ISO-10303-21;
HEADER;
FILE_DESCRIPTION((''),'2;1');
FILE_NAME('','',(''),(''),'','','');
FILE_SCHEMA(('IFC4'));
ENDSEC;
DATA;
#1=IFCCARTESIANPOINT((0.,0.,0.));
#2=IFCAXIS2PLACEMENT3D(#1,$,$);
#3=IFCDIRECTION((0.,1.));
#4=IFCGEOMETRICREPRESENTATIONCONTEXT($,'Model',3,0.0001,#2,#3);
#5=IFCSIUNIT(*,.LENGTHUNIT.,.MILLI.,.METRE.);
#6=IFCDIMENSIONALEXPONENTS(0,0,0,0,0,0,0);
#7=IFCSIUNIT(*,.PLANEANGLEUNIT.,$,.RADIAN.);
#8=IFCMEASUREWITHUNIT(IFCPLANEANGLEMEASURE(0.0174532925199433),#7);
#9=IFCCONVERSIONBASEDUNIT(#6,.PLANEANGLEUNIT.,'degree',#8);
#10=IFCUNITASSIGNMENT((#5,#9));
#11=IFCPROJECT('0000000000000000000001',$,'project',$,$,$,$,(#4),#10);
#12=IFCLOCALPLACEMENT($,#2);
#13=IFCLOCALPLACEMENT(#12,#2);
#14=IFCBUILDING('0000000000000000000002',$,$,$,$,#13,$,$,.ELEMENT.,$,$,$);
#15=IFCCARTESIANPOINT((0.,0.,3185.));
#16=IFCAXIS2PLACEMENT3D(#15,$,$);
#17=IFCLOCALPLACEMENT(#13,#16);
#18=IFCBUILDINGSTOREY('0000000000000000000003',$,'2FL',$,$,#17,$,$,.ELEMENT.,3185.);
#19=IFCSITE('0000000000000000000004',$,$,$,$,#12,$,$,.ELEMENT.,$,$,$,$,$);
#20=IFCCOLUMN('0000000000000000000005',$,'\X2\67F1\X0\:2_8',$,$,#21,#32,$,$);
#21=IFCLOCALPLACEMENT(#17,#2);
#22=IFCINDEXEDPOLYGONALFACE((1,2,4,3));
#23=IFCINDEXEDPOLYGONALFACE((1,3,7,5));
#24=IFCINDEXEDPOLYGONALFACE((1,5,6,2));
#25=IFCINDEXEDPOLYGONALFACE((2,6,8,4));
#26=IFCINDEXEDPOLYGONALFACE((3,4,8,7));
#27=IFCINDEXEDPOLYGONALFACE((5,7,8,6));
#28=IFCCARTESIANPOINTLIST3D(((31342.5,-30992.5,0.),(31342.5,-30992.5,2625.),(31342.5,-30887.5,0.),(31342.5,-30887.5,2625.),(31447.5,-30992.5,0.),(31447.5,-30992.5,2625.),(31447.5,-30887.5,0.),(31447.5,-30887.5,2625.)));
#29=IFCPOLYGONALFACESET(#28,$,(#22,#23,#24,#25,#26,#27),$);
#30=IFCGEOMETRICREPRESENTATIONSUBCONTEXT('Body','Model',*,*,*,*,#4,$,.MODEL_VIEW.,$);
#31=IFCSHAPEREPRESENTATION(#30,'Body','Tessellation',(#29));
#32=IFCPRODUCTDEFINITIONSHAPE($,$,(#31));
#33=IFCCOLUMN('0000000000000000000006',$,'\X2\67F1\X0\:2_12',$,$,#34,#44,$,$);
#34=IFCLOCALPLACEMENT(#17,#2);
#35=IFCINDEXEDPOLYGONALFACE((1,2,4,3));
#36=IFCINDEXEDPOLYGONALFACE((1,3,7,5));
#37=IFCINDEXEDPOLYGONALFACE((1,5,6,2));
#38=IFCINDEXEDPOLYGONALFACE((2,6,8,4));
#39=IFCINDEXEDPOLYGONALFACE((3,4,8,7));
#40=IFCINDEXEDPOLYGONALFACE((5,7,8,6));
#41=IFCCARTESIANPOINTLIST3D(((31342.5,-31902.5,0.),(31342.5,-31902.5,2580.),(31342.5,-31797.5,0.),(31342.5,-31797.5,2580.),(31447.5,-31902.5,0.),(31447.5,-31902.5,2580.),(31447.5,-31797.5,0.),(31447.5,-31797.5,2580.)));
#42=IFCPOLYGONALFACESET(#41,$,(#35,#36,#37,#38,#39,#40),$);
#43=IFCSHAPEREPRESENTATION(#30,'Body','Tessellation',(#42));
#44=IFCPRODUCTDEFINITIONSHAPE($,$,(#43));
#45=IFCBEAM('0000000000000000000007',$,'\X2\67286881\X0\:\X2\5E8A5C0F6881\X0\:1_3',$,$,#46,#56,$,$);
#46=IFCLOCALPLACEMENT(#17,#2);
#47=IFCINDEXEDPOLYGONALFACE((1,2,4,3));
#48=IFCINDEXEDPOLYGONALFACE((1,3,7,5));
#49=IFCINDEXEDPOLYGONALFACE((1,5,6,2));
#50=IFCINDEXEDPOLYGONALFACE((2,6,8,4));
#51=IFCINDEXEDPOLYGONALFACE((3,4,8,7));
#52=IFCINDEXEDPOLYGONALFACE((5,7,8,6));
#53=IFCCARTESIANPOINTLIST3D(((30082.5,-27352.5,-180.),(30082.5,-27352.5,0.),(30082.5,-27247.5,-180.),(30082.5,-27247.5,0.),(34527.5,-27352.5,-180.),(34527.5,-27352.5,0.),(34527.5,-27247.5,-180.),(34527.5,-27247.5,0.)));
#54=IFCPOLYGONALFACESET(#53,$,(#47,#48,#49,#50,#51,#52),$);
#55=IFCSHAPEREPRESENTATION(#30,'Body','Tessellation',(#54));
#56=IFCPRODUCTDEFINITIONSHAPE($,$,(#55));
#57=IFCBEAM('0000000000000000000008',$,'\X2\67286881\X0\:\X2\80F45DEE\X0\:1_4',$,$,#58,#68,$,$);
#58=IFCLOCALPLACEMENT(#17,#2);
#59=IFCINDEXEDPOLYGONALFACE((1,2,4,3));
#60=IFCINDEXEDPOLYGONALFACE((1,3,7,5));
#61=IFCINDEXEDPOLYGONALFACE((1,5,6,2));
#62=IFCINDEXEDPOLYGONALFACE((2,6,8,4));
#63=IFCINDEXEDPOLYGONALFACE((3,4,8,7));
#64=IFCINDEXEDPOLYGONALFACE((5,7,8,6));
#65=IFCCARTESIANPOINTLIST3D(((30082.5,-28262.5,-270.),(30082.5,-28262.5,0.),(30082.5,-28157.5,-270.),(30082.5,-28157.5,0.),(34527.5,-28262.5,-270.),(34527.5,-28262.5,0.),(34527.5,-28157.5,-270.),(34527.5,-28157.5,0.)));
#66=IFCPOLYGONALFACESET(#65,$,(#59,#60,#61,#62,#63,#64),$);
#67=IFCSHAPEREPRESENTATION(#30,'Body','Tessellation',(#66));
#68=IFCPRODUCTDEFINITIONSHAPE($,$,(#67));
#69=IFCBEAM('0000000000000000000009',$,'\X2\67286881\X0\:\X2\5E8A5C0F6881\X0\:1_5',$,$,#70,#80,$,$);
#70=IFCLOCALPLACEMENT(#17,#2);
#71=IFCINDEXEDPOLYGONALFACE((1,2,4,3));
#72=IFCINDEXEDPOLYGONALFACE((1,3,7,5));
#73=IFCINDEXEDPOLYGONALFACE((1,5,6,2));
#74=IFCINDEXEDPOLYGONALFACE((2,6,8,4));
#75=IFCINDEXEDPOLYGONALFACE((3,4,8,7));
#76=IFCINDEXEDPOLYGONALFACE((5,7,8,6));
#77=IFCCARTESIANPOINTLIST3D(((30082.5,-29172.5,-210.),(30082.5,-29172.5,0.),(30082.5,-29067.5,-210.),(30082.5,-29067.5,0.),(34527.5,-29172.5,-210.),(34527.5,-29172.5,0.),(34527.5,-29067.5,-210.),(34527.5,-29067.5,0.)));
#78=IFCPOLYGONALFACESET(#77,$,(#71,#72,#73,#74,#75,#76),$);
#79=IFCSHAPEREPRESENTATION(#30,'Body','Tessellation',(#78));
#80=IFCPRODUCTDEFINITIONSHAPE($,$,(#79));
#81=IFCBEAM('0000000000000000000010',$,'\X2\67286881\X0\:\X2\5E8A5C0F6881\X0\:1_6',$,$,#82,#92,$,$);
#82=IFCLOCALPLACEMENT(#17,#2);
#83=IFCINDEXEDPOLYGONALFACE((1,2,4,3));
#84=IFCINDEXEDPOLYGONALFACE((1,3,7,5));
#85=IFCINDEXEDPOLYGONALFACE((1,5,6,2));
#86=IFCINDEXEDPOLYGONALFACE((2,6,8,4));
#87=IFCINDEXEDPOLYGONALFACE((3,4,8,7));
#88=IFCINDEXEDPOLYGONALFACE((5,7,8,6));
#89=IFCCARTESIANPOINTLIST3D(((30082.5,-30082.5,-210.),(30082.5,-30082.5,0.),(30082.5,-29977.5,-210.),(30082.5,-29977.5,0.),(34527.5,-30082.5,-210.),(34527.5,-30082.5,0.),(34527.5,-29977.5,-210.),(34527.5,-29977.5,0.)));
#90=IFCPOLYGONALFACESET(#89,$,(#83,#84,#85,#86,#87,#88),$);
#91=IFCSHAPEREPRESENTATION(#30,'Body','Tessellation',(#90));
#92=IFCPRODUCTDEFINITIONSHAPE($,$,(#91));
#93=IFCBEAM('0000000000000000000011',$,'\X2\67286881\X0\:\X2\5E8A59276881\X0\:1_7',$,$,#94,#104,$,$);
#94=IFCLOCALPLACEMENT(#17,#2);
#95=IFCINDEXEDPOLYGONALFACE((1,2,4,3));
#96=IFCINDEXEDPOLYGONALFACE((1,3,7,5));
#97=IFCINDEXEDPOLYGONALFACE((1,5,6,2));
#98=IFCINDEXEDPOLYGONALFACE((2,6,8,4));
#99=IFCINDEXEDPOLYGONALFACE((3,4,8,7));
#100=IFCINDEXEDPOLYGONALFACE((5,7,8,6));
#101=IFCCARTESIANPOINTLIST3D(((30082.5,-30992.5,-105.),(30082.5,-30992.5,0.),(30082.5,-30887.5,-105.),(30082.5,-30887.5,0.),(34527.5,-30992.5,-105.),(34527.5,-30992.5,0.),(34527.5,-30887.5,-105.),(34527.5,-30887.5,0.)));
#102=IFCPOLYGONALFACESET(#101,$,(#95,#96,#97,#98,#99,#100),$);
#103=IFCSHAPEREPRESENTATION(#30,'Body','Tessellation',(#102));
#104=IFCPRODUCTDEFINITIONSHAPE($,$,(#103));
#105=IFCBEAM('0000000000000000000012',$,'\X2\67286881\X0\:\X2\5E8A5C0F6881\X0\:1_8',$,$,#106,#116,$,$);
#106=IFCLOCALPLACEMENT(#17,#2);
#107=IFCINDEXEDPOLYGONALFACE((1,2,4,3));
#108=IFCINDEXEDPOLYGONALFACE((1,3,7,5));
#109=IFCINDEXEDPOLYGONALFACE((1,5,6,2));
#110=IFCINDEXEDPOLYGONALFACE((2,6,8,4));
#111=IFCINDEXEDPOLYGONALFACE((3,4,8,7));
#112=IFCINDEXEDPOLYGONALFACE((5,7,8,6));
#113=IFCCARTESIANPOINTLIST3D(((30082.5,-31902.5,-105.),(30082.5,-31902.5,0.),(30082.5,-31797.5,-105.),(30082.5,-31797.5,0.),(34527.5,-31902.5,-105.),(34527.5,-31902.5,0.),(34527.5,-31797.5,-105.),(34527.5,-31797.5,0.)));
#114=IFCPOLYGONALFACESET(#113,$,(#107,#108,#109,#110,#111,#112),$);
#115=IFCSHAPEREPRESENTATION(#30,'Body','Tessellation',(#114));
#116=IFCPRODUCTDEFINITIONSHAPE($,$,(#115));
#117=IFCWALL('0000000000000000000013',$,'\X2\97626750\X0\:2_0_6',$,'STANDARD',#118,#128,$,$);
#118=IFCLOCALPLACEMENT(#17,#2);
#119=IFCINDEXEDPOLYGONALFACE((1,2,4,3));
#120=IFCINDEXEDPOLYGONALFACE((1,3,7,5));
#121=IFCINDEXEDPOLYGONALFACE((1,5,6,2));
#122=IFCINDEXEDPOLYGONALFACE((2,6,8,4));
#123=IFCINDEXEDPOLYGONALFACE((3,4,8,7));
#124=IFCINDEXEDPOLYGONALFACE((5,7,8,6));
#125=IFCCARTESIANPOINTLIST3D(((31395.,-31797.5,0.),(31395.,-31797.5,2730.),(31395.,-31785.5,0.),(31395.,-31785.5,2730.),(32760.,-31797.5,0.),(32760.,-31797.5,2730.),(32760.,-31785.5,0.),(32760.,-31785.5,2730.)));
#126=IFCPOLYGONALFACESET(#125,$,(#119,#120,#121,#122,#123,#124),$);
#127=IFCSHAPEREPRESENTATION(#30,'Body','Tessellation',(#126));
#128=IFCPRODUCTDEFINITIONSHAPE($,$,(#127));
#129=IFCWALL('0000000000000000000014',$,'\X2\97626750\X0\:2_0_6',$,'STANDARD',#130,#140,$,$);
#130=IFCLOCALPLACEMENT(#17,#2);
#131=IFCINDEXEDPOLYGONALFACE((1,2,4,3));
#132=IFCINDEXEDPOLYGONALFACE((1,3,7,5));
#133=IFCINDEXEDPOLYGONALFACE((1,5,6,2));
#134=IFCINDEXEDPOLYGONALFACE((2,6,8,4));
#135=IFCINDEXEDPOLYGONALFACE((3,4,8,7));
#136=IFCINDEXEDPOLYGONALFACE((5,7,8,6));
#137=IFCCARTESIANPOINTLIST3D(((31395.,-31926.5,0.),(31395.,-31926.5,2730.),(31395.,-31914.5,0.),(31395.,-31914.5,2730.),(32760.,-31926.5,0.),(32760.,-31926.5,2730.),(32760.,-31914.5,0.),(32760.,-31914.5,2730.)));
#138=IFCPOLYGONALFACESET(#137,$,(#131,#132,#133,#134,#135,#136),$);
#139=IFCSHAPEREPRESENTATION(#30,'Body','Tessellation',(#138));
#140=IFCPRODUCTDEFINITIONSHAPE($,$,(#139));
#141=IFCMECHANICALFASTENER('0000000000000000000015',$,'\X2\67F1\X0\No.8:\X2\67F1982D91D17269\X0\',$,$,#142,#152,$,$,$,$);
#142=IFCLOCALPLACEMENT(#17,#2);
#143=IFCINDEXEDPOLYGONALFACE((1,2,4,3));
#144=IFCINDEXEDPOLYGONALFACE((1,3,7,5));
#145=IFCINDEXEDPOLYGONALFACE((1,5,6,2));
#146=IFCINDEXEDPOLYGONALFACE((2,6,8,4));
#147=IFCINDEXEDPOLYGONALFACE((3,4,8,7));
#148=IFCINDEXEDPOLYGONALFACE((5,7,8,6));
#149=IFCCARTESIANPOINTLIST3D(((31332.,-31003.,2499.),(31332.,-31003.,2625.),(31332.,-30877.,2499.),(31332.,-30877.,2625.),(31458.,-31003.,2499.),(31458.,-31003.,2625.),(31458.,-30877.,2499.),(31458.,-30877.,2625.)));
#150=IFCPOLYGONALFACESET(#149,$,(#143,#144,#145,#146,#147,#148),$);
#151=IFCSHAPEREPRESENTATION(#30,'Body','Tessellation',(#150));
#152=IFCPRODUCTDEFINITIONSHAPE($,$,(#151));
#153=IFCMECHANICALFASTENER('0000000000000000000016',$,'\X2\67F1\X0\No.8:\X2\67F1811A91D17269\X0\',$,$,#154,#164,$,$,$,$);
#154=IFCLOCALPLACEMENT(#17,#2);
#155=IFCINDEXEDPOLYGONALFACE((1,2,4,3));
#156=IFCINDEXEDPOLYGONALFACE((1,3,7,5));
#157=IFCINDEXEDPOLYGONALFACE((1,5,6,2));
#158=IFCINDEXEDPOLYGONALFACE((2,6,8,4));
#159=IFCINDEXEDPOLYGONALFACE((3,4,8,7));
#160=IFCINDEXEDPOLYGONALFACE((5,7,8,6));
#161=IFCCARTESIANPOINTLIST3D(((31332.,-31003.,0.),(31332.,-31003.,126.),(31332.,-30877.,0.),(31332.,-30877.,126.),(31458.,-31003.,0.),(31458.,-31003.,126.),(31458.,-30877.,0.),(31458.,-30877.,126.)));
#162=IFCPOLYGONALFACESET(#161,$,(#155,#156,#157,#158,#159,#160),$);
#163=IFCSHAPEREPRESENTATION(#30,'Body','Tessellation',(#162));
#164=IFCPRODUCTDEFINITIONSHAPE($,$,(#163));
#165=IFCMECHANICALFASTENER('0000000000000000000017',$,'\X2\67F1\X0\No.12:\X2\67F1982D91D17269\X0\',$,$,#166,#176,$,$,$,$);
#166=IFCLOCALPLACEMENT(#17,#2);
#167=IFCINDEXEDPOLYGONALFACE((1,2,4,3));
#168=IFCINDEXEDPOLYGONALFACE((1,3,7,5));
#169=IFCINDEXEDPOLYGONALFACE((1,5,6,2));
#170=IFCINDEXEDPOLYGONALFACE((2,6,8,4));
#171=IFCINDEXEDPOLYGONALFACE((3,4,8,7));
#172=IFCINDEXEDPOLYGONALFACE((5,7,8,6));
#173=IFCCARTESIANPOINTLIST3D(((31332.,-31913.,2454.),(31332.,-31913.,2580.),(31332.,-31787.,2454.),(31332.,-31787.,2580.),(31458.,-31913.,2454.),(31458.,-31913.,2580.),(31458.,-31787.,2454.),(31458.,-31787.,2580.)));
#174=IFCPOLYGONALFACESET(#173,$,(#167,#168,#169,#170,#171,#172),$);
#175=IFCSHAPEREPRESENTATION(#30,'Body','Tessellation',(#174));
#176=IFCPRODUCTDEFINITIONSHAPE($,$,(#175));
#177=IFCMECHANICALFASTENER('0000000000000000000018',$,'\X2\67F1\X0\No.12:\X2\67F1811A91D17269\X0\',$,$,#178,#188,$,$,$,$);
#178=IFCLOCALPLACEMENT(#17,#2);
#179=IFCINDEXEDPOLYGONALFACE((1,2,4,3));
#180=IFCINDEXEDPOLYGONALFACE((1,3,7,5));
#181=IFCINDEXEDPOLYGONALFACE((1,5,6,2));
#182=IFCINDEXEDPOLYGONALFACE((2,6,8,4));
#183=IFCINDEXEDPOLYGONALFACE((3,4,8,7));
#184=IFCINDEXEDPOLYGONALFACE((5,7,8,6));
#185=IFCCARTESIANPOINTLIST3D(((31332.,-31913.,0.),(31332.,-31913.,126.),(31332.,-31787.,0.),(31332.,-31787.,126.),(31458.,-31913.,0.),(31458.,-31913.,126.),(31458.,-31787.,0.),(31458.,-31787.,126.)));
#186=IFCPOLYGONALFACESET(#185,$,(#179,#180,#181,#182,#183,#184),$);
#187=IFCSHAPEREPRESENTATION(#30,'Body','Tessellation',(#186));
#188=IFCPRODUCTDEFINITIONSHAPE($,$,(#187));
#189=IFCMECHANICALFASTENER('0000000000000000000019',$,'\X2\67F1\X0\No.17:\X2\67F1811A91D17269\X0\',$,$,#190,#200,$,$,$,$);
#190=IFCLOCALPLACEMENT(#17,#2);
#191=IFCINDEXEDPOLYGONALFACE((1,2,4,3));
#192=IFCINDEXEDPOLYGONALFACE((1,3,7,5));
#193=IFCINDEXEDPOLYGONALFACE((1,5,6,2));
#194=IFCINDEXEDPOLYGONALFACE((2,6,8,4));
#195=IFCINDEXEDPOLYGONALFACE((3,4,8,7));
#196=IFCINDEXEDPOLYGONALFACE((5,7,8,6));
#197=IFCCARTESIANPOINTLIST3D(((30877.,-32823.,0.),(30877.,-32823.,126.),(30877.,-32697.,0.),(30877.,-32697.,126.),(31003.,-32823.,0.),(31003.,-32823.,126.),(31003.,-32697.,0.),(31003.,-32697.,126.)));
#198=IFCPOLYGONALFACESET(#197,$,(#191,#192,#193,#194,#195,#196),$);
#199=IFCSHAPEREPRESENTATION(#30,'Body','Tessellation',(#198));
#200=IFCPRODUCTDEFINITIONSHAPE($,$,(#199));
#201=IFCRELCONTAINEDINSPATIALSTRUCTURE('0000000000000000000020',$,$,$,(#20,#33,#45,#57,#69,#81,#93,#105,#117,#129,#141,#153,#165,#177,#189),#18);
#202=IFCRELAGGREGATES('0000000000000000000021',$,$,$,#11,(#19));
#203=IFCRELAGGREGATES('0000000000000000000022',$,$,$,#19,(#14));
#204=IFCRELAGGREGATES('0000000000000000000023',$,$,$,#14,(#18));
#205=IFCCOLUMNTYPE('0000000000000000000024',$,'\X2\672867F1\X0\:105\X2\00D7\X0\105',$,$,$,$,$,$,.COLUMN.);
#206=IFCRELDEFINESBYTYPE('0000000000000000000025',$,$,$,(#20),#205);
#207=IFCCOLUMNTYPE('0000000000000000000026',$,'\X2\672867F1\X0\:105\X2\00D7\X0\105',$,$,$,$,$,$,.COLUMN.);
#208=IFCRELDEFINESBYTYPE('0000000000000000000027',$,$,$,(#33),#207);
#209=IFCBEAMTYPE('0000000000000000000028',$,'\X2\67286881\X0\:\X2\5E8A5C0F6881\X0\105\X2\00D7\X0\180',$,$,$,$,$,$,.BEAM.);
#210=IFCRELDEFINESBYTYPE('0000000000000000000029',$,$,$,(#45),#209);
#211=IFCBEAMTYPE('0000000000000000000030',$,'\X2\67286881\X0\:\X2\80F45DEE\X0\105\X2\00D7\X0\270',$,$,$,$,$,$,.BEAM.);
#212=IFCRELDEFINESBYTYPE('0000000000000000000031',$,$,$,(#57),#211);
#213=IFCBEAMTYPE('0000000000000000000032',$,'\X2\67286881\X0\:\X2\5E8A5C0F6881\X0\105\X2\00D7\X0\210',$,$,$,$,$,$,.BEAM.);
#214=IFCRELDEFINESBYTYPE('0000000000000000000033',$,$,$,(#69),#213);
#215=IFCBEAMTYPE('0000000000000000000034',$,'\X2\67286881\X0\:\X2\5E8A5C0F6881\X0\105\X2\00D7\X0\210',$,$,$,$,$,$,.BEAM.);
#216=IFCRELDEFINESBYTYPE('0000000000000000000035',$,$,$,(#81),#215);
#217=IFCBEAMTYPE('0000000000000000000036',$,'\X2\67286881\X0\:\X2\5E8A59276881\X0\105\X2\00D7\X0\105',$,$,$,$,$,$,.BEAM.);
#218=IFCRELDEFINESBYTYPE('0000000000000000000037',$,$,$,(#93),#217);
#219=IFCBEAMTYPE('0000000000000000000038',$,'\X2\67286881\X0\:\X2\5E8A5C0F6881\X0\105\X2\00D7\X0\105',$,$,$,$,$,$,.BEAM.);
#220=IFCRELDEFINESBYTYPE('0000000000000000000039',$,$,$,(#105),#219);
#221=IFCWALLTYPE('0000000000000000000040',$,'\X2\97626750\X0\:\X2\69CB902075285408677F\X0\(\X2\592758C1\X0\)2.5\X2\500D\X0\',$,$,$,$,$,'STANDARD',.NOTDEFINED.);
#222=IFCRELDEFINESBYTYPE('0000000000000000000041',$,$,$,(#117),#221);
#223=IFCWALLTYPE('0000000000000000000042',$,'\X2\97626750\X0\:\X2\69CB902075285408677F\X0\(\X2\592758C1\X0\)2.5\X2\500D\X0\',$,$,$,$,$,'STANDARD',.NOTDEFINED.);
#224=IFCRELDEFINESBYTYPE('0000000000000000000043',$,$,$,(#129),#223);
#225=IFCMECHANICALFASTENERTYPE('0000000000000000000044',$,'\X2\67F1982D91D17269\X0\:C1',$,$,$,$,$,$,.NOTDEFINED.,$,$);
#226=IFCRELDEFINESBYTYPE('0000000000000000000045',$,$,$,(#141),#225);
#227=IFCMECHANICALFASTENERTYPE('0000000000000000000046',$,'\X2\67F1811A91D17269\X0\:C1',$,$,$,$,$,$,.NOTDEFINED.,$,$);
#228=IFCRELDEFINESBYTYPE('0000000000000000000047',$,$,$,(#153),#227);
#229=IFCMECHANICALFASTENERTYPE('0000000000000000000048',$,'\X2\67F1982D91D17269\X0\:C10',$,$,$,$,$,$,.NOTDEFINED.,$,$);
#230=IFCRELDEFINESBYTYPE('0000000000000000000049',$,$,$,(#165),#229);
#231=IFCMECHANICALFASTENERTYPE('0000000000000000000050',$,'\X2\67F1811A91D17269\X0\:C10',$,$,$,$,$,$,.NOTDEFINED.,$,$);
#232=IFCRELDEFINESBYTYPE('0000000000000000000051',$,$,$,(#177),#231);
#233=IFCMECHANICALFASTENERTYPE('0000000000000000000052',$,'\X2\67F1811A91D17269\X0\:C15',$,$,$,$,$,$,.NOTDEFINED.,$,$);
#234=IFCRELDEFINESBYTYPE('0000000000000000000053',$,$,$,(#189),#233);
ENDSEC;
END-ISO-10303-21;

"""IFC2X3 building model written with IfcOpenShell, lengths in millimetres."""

from ifc_helpers import new_model, entity, si_unit, converted_unit, direction, frame, origin, origin_with_axes, origin_2d, place, context, subcontext, project, spatial, polyline, rectangle, outline, extrude, type_object, element, save


model = new_model("IFC2X3")

# Units and contexts
model_context = context("Model", 3, precision=0.0001, world=origin(), true_north=direction((0.0, 1.0)))
body_context = subcontext(model_context, "Body", "Model", "MODEL_VIEW")
ifc_project = project(units=[si_unit("LENGTHUNIT", "METRE", prefix="MILLI"), converted_unit("PLANEANGLEUNIT", "degree", entity("IfcPlaneAngleMeasure", 0.0174532925199433), si_unit("PLANEANGLEUNIT", "RADIAN"), dimensions=[0, 0, 0, 0, 0, 0, 0])], contexts=[model_context])

# Site, building, storey
site_placement = place(None, origin())
site = spatial("IfcSite", under=ifc_project, at=site_placement, CompositionType="ELEMENT")
building_placement = place(site_placement, origin())
building = spatial("IfcBuilding", under=site, at=building_placement, CompositionType="ELEMENT")
storey_placement = place(building_placement, frame((0.0, 0.0, 3185.0)))
storey = spatial("IfcBuildingStorey", under=building, at=storey_placement, Name="2FL", CompositionType="ELEMENT", Elevation=3185.0)

# Columns
column_type_1 = type_object("IfcColumnType", Name="木柱:105×105", PredefinedType="COLUMN")
column_1_placement = place(storey_placement, frame((31395.0, -30940.0, 0.0)))
element("IfcColumn", 1, at=column_1_placement, inside=storey, type_object=column_type_1, Name="柱:2_8", context=body_context, shape_type="SweptSolid", body=[
    extrude(rectangle(XDim=105.0, YDim=105.0, at=origin_2d()), origin_with_axes(), (0.0, 0.0, 1.0), 2625.0),
])
column_type_2 = type_object("IfcColumnType", Name="木柱:105×105", PredefinedType="COLUMN")
column_2_placement = place(storey_placement, frame((31395.0, -31850.0, 0.0)))
element("IfcColumn", 2, at=column_2_placement, inside=storey, type_object=column_type_2, Name="柱:2_12", context=body_context, shape_type="SweptSolid", body=[
    extrude(rectangle(XDim=105.0, YDim=105.0, at=origin_2d()), origin_with_axes(), (0.0, 0.0, 1.0), 2580.0),
])

# Beams
beam_type_1 = type_object("IfcBeamType", Name="木梁:床小梁105×180", PredefinedType="BEAM")
beam_1_placement = place(storey_placement, frame((30082.5, -27300.0, -90.0), z_axis=(1.0, 0.0, 0.0), x_axis=(0.0, 1.0, 0.0)))
element("IfcBeam", 3, at=beam_1_placement, inside=storey, type_object=beam_type_1, Name="木梁:床小梁:1_3", context=body_context, shape_type="SweptSolid", body=[
    extrude(rectangle(XDim=105.0, YDim=180.0, at=origin_2d()), origin_with_axes(), (0.0, 0.0, 1.0), 4445.0),
])
beam_type_2 = type_object("IfcBeamType", Name="木梁:胴差105×270", PredefinedType="BEAM")
beam_2_placement = place(storey_placement, frame((30082.5, -28210.0, -135.0), z_axis=(1.0, 0.0, 0.0), x_axis=(0.0, 1.0, 0.0)))
element("IfcBeam", 4, at=beam_2_placement, inside=storey, type_object=beam_type_2, Name="木梁:胴差:1_4", context=body_context, shape_type="SweptSolid", body=[
    extrude(rectangle(XDim=105.0, YDim=270.0, at=origin_2d()), origin_with_axes(), (0.0, 0.0, 1.0), 4445.0),
])
beam_type_3 = type_object("IfcBeamType", Name="木梁:床小梁105×210", PredefinedType="BEAM")
beam_3_placement = place(storey_placement, frame((30082.5, -29120.0, -105.0), z_axis=(1.0, 0.0, 0.0), x_axis=(0.0, 1.0, 0.0)))
element("IfcBeam", 5, at=beam_3_placement, inside=storey, type_object=beam_type_3, Name="木梁:床小梁:1_5", context=body_context, shape_type="SweptSolid", body=[
    extrude(rectangle(XDim=105.0, YDim=210.0, at=origin_2d()), origin_with_axes(), (0.0, 0.0, 1.0), 4445.0),
])
beam_type_4 = type_object("IfcBeamType", Name="木梁:床小梁105×210", PredefinedType="BEAM")
beam_4_placement = place(storey_placement, frame((30082.5, -30030.0, -105.0), z_axis=(1.0, 0.0, 0.0), x_axis=(0.0, 1.0, 0.0)))
element("IfcBeam", 6, at=beam_4_placement, inside=storey, type_object=beam_type_4, Name="木梁:床小梁:1_6", context=body_context, shape_type="SweptSolid", body=[
    extrude(rectangle(XDim=105.0, YDim=210.0, at=origin_2d()), origin_with_axes(), (0.0, 0.0, 1.0), 4445.0),
])
beam_type_5 = type_object("IfcBeamType", Name="木梁:床大梁105×105", PredefinedType="BEAM")
beam_5_placement = place(storey_placement, frame((30082.5, -30940.0, -52.5), z_axis=(1.0, 0.0, 0.0), x_axis=(0.0, 1.0, 0.0)))
element("IfcBeam", 7, at=beam_5_placement, inside=storey, type_object=beam_type_5, Name="木梁:床大梁:1_7", context=body_context, shape_type="SweptSolid", body=[
    extrude(rectangle(XDim=105.0, YDim=105.0, at=origin_2d()), origin_with_axes(), (0.0, 0.0, 1.0), 4445.0),
])
beam_type_6 = type_object("IfcBeamType", Name="木梁:床小梁105×105", PredefinedType="BEAM")
beam_6_placement = place(storey_placement, frame((30082.5, -31850.0, -52.5), z_axis=(1.0, 0.0, 0.0), x_axis=(0.0, 1.0, 0.0)))
element("IfcBeam", 8, at=beam_6_placement, inside=storey, type_object=beam_type_6, Name="木梁:床小梁:1_8", context=body_context, shape_type="SweptSolid", body=[
    extrude(rectangle(XDim=105.0, YDim=105.0, at=origin_2d()), origin_with_axes(), (0.0, 0.0, 1.0), 4445.0),
])

# Walls
wall_type_1 = type_object("IfcWallType", Name="面材:構造用合板(大壁)2.5倍", ElementType="STANDARD", PredefinedType="NOTDEFINED")
wall_1_placement = place(storey_placement, frame((32077.5, -31785.5, 0.0), z_axis=(0.0, -1.0, 0.0), x_axis=(1.0, 0.0, 0.0)))
element("IfcWall", 9, at=wall_1_placement, inside=storey, type_object=wall_type_1, Name="面材:2_0_6", ObjectType="STANDARD", context=body_context, shape_type="SweptSolid", body=[
    extrude(outline(polyline([(682.5, 0.0, 0.0), (-682.5, 0.0, 0.0), (-682.5, 2730.0, 0.0), (682.5, 2730.0, 0.0), (682.5, 0.0, 0.0)])), origin_with_axes(), (0.0, 0.0, 1.0), 12.0),
])
wall_type_2 = type_object("IfcWallType", Name="面材:構造用合板(大壁)2.5倍", ElementType="STANDARD", PredefinedType="NOTDEFINED")
wall_2_placement = place(storey_placement, frame((32077.5, -31914.5, 0.0), z_axis=(0.0, -1.0, 0.0), x_axis=(1.0, 0.0, 0.0)))
element("IfcWall", 10, at=wall_2_placement, inside=storey, type_object=wall_type_2, Name="面材:2_0_6", ObjectType="STANDARD", context=body_context, shape_type="SweptSolid", body=[
    extrude(outline(polyline([(682.5, 0.0, 0.0), (-682.5, 0.0, 0.0), (-682.5, 2730.0, 0.0), (682.5, 2730.0, 0.0), (682.5, 0.0, 0.0)])), origin_with_axes(), (0.0, 0.0, 1.0), 12.0),
])

# Mechanical fasteners
mechanical_fastener_type_1 = type_object("IfcMechanicalFastenerType", Name="柱頭金物:C1")
mechanical_fastener_1_placement = place(storey_placement, frame((31395.0, -30940.0, 2499.0)))
element("IfcMechanicalFastener", 11, at=mechanical_fastener_1_placement, inside=storey, type_object=mechanical_fastener_type_1, Name="柱No.8:柱頭金物", context=body_context, shape_type="SweptSolid", body=[
    extrude(rectangle(XDim=126.0, YDim=126.0, at=origin_2d()), origin_with_axes(), (0.0, 0.0, 1.0), 126.0),
])
mechanical_fastener_type_2 = type_object("IfcMechanicalFastenerType", Name="柱脚金物:C1")
mechanical_fastener_2_placement = place(storey_placement, frame((31395.0, -30940.0, 0.0)))
element("IfcMechanicalFastener", 12, at=mechanical_fastener_2_placement, inside=storey, type_object=mechanical_fastener_type_2, Name="柱No.8:柱脚金物", context=body_context, shape_type="SweptSolid", body=[
    extrude(rectangle(XDim=126.0, YDim=126.0, at=origin_2d()), origin_with_axes(), (0.0, 0.0, 1.0), 126.0),
])
mechanical_fastener_type_3 = type_object("IfcMechanicalFastenerType", Name="柱頭金物:C10")
mechanical_fastener_3_placement = place(storey_placement, frame((31395.0, -31850.0, 2454.0)))
element("IfcMechanicalFastener", 13, at=mechanical_fastener_3_placement, inside=storey, type_object=mechanical_fastener_type_3, Name="柱No.12:柱頭金物", context=body_context, shape_type="SweptSolid", body=[
    extrude(rectangle(XDim=126.0, YDim=126.0, at=origin_2d()), origin_with_axes(), (0.0, 0.0, 1.0), 126.0),
])
mechanical_fastener_type_4 = type_object("IfcMechanicalFastenerType", Name="柱脚金物:C10")
mechanical_fastener_4_placement = place(storey_placement, frame((31395.0, -31850.0, 0.0)))
element("IfcMechanicalFastener", 14, at=mechanical_fastener_4_placement, inside=storey, type_object=mechanical_fastener_type_4, Name="柱No.12:柱脚金物", context=body_context, shape_type="SweptSolid", body=[
    extrude(rectangle(XDim=126.0, YDim=126.0, at=origin_2d()), origin_with_axes(), (0.0, 0.0, 1.0), 126.0),
])
mechanical_fastener_type_5 = type_object("IfcMechanicalFastenerType", Name="柱脚金物:C15")
mechanical_fastener_5_placement = place(storey_placement, frame((30940.0, -32760.0, 0.0)))
element("IfcMechanicalFastener", 15, at=mechanical_fastener_5_placement, inside=storey, type_object=mechanical_fastener_type_5, Name="柱No.17:柱脚金物", context=body_context, shape_type="SweptSolid", body=[
    extrude(rectangle(XDim=126.0, YDim=126.0, at=origin_2d()), origin_with_axes(), (0.0, 0.0, 1.0), 126.0),
])

save(model, "model.ifc")
